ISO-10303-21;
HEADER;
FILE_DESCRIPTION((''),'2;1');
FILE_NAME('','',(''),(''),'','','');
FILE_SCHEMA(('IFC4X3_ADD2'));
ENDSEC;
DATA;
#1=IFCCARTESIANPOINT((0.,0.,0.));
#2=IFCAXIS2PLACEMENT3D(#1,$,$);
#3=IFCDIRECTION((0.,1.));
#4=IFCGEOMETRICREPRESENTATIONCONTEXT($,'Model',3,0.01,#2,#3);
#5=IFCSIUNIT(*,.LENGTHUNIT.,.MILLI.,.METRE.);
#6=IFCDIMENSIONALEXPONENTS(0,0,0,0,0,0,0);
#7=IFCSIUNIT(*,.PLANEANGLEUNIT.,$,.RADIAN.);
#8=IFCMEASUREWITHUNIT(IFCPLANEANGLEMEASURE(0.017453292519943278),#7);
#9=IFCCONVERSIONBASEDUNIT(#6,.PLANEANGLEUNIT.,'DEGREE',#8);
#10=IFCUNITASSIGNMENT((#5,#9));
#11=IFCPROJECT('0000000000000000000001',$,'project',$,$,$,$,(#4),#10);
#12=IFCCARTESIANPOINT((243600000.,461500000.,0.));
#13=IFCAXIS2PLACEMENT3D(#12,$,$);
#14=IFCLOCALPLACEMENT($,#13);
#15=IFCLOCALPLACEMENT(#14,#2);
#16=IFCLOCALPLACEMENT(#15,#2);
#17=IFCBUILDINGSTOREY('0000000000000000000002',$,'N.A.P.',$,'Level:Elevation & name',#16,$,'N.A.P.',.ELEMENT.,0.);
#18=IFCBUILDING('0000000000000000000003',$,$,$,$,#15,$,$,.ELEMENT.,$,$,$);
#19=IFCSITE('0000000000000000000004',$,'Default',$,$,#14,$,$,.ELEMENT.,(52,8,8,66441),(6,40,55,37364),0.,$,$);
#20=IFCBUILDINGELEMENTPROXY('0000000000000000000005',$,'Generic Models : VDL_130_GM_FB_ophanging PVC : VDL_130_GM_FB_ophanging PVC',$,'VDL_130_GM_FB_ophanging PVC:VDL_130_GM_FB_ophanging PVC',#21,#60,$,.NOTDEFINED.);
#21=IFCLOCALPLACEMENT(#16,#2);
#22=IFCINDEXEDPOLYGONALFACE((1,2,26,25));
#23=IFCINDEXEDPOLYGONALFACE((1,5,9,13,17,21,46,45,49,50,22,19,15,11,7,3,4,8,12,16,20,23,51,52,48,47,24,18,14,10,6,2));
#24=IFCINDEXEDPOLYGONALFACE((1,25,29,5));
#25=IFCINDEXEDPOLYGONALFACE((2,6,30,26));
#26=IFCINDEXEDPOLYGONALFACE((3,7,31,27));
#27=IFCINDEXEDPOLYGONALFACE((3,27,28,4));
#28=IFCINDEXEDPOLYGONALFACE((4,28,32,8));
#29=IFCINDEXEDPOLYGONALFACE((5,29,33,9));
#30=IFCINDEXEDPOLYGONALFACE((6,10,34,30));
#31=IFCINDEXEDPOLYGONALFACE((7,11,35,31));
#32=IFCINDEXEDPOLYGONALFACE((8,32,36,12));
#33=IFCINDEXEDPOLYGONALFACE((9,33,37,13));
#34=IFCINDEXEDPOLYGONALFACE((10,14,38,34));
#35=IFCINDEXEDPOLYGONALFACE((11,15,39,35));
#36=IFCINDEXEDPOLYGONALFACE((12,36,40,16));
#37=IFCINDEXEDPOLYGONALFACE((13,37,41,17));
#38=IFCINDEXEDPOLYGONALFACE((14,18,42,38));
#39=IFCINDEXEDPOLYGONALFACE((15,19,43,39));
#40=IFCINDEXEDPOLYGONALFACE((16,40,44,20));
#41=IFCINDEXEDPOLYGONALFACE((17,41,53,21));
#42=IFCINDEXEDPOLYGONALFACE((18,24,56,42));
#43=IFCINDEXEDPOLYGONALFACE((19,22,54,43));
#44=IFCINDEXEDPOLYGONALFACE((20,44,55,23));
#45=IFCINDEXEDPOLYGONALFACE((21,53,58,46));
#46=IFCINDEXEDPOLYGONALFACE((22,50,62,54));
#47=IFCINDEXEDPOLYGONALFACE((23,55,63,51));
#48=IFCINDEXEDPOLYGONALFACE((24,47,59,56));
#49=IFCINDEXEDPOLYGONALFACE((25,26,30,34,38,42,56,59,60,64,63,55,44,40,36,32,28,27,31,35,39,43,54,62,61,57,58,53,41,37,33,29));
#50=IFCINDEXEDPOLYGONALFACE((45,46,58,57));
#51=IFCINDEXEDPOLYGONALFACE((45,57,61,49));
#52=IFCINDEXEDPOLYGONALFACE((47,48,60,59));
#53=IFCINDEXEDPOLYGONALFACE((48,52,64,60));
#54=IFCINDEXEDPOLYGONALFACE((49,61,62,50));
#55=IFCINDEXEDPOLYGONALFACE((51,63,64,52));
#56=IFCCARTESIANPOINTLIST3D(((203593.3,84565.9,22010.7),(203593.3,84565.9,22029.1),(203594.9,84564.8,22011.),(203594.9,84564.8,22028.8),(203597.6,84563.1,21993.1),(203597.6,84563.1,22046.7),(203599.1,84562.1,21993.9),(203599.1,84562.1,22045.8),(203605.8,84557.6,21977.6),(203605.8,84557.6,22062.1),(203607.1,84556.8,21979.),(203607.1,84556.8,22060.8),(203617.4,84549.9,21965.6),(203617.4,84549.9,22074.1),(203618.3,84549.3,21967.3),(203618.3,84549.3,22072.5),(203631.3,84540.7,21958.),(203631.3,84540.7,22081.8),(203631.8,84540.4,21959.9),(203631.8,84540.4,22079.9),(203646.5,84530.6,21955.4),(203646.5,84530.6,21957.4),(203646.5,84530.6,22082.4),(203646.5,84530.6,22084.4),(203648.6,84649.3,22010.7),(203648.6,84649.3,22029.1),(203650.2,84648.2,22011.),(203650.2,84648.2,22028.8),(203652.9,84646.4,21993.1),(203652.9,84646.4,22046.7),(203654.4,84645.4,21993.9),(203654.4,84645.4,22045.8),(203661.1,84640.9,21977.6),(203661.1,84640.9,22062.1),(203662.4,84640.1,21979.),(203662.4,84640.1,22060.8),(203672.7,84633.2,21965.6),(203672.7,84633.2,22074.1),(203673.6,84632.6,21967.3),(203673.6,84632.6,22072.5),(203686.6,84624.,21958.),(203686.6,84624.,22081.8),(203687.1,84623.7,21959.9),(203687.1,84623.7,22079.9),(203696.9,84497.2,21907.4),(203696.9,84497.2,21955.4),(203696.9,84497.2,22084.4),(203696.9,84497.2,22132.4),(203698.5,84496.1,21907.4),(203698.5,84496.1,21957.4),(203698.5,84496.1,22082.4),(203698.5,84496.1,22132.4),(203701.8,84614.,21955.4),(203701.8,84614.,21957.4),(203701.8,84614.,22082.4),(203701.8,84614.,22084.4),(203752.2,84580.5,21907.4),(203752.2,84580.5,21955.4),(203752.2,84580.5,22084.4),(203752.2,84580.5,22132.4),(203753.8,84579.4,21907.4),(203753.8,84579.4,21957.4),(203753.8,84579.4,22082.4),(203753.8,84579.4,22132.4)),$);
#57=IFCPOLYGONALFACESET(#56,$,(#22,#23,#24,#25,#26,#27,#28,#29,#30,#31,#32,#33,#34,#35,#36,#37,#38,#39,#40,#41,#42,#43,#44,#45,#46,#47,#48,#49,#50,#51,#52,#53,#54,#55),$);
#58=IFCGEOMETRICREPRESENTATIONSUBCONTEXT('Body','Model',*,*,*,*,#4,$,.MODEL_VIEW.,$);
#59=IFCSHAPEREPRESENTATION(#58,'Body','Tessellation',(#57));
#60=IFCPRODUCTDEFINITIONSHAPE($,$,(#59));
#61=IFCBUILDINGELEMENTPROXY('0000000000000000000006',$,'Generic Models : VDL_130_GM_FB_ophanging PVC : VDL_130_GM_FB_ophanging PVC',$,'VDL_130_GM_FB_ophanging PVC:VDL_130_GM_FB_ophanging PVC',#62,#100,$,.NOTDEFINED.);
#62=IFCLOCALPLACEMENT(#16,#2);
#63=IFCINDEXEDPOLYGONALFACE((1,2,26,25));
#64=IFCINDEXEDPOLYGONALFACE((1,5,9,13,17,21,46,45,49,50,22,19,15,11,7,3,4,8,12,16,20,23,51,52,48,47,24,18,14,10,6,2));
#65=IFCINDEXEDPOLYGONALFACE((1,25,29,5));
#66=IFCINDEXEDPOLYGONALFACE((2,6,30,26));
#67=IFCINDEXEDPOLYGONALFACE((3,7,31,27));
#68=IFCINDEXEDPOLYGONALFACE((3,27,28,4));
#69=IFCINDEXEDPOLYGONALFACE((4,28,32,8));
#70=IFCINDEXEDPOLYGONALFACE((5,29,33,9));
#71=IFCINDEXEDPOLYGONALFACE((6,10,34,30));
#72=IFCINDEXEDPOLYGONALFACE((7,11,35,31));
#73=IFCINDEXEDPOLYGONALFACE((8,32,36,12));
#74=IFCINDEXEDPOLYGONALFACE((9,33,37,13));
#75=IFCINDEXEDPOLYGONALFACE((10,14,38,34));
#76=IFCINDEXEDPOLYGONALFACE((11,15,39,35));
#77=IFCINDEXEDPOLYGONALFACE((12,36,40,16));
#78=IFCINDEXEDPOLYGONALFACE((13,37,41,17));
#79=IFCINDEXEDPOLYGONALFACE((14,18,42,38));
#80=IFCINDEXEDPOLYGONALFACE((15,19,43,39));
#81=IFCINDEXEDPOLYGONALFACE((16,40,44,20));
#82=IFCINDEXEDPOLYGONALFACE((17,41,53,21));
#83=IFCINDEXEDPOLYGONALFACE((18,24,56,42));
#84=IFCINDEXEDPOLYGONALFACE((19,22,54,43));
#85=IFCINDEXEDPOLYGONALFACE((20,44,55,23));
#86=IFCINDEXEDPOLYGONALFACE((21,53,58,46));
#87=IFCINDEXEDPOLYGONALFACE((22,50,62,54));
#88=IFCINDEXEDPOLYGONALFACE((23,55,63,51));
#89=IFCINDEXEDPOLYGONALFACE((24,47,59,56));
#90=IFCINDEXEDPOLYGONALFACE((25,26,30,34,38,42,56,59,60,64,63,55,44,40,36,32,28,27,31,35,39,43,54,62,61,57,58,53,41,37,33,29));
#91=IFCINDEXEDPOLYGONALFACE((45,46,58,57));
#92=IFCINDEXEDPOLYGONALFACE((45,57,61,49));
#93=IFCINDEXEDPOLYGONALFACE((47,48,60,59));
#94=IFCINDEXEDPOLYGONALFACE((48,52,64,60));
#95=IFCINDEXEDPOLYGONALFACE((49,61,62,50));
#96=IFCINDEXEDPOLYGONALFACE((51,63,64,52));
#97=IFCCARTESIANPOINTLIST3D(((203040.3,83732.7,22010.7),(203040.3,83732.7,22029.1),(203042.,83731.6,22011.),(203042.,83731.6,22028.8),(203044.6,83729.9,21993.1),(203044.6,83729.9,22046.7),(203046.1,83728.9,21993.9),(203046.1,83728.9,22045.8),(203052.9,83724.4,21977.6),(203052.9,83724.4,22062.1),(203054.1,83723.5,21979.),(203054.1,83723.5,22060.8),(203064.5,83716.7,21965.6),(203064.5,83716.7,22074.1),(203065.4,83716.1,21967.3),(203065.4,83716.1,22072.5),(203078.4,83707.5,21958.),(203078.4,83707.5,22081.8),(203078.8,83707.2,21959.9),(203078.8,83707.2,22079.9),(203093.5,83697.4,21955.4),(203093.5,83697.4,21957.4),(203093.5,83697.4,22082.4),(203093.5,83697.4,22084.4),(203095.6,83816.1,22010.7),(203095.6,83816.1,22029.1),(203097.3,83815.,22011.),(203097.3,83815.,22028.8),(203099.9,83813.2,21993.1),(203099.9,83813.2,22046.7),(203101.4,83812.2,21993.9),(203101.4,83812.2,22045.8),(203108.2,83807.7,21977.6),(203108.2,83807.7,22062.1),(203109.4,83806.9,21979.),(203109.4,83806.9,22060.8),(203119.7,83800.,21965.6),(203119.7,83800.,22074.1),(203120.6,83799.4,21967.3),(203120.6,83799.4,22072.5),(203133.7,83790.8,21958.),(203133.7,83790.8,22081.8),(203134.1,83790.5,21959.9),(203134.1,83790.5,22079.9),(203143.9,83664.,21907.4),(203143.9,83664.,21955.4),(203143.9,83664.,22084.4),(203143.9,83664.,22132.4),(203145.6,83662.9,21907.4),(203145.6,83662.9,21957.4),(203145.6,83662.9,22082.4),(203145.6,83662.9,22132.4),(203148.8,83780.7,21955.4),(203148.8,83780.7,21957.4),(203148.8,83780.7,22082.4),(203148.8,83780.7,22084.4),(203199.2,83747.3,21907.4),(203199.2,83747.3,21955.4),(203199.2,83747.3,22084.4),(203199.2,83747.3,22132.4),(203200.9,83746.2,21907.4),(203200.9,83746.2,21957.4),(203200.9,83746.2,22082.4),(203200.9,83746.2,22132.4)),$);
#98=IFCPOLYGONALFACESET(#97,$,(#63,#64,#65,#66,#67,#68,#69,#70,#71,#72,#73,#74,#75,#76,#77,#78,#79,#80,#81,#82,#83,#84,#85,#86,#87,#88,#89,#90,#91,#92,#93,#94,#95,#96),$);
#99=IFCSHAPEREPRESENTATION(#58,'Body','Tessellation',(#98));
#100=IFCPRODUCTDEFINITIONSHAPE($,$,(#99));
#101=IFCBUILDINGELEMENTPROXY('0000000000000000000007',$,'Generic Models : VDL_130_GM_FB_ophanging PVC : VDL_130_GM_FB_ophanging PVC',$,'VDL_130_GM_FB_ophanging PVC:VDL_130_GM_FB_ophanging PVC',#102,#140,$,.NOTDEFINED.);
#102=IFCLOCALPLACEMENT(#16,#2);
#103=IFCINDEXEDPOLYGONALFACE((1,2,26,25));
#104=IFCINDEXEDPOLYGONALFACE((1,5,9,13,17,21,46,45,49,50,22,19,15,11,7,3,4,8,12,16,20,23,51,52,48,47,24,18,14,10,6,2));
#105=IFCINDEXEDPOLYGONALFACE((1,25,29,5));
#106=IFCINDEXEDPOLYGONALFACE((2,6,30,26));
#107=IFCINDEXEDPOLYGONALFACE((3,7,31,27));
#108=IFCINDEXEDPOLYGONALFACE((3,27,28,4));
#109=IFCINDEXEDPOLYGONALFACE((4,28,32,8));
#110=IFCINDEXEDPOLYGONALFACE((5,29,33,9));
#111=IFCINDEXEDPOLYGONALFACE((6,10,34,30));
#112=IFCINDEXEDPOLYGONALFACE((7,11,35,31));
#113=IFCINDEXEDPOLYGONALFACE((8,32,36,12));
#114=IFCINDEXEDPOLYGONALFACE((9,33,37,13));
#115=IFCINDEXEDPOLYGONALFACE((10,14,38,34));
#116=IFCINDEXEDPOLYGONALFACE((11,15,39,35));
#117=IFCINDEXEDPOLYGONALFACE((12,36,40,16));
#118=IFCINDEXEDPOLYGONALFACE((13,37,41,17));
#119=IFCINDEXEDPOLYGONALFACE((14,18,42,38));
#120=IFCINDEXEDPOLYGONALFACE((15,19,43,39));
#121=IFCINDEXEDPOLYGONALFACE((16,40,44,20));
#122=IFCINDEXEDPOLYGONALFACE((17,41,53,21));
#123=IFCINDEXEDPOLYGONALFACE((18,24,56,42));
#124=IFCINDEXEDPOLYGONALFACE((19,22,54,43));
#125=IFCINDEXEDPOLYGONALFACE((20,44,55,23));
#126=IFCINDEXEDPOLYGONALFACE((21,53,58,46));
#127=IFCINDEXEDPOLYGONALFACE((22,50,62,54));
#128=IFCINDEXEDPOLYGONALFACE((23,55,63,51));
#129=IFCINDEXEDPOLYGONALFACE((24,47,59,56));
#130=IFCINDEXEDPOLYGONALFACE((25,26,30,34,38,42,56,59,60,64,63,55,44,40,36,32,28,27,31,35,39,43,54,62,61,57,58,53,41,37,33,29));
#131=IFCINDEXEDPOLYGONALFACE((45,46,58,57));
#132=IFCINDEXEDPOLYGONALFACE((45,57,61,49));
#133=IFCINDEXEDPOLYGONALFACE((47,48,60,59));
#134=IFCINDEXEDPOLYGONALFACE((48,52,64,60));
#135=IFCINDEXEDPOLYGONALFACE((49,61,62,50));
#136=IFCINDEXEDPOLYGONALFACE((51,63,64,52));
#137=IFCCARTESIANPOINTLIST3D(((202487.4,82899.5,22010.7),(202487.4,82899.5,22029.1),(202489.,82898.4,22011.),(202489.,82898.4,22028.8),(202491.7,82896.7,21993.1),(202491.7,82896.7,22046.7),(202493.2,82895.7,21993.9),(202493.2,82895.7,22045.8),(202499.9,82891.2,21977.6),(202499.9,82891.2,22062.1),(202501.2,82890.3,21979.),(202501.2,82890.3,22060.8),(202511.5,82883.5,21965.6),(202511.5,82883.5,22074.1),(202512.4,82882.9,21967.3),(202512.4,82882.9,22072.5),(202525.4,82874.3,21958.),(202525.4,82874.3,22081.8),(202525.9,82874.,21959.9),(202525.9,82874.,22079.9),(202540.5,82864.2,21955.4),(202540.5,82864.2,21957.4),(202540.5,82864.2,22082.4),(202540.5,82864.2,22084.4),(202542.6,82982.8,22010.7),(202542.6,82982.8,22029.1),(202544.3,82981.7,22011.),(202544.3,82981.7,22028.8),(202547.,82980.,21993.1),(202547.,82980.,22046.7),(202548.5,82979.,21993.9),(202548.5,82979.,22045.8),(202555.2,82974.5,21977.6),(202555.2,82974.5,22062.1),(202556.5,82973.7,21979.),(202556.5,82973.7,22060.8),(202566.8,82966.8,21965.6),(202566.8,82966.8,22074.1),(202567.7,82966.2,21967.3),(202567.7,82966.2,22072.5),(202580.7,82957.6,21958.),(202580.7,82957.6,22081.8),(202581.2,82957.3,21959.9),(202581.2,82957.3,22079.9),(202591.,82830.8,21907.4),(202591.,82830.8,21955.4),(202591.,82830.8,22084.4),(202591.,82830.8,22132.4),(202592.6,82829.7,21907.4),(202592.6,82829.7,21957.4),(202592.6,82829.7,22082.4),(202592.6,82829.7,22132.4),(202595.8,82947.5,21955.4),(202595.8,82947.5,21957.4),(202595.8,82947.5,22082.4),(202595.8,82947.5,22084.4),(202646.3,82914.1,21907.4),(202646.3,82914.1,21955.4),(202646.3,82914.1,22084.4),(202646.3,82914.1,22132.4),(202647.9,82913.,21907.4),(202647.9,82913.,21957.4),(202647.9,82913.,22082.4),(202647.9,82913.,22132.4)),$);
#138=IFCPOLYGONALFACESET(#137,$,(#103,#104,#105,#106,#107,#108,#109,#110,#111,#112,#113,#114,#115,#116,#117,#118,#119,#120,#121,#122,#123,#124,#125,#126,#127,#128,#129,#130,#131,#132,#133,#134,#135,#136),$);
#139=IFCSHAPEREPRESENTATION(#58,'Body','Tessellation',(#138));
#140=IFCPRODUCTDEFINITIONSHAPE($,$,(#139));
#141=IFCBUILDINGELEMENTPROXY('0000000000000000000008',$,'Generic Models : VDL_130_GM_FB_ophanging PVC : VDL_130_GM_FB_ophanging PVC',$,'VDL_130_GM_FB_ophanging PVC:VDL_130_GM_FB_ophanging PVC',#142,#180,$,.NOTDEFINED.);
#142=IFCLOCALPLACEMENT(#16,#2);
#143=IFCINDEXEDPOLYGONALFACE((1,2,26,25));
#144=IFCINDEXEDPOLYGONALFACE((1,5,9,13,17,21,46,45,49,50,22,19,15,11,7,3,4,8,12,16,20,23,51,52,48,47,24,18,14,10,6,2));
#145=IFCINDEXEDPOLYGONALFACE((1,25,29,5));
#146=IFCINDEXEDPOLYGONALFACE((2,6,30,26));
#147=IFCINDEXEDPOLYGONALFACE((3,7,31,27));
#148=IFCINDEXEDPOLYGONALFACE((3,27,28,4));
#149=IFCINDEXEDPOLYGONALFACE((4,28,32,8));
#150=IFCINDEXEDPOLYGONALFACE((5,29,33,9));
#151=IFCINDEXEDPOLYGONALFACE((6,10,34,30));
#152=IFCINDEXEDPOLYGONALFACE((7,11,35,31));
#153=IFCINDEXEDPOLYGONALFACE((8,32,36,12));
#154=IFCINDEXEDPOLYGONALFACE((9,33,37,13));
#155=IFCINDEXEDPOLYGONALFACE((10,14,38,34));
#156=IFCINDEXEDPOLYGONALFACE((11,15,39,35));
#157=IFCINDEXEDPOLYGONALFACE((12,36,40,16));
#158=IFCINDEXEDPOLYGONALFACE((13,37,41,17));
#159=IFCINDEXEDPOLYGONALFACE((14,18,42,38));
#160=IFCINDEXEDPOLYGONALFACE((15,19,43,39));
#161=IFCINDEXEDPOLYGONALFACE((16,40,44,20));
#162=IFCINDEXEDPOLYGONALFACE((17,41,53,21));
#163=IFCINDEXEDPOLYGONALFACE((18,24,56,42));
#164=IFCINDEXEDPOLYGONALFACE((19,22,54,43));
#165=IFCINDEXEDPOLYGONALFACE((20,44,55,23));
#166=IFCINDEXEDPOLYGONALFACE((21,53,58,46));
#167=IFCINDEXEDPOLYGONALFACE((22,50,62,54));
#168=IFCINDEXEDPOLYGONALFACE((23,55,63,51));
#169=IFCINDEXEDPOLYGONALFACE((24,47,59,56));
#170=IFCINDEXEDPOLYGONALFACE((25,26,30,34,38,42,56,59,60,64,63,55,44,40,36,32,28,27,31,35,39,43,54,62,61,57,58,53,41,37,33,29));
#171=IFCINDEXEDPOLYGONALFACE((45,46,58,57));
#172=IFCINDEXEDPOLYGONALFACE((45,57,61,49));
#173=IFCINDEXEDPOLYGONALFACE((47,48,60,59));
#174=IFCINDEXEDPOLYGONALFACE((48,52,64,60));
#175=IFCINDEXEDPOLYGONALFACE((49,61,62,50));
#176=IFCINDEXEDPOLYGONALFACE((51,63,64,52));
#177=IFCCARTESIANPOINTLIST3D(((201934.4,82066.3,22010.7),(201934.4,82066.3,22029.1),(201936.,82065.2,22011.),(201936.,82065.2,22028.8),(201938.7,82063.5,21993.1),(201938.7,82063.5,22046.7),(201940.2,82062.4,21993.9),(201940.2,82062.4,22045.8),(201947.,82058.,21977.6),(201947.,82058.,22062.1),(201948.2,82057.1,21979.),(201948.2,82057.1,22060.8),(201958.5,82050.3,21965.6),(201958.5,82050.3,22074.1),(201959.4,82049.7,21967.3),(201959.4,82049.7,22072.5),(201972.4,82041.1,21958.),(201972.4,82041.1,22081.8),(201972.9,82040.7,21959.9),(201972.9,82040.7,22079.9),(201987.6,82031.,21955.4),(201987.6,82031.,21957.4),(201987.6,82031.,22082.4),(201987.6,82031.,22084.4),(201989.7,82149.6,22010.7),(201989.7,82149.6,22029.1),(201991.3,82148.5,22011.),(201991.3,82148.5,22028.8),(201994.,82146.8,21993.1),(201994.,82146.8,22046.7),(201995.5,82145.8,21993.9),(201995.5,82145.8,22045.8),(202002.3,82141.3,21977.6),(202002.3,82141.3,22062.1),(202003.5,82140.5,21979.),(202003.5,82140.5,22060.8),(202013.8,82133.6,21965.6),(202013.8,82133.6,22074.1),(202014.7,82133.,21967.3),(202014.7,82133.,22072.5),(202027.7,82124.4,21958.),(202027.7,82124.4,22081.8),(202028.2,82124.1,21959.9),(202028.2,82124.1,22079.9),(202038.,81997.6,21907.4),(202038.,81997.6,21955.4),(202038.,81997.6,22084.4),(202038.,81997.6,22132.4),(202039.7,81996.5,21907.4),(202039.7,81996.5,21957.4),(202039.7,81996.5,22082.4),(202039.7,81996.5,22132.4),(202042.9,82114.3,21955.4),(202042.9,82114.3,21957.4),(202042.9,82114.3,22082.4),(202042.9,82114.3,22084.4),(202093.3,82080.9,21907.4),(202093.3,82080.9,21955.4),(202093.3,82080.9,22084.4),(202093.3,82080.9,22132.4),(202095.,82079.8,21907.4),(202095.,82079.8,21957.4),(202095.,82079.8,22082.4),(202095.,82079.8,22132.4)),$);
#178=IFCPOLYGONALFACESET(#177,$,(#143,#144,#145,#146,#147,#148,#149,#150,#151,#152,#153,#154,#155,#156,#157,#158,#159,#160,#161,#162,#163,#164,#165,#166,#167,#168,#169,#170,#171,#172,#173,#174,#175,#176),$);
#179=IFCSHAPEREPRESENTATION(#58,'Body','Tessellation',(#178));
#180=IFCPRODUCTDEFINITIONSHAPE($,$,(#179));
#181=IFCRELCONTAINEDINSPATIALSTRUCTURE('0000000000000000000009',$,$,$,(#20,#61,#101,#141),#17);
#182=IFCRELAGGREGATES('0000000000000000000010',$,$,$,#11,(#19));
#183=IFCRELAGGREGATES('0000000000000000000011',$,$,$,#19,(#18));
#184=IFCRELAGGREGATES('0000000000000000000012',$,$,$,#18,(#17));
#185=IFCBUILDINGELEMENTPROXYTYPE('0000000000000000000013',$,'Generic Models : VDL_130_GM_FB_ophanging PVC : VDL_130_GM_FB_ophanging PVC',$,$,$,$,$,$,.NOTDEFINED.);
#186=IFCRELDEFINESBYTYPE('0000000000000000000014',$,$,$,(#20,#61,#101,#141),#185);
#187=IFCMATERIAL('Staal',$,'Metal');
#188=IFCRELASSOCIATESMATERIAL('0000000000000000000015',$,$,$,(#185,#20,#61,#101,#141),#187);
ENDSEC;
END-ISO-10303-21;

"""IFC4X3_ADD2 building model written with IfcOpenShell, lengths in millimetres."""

from ifc_helpers import new_model, entity, si_unit, converted_unit, direction, frame, frame_2d, origin, place, context, subcontext, project, spatial, polyline, circle_curve, parameter, trimmed, segment, composite_curve, outline, extrude, source, transform, mapped, material, type_object, type_shapes, element, save


model = new_model("IFC4X3_ADD2")

# Units and contexts
model_context = context("Model", 3, precision=0.01, world=origin(), true_north=direction((0.0, 1.0)))
body_context = subcontext(model_context, "Body", "Model", "MODEL_VIEW")
ifc_project = project(units=[si_unit("LENGTHUNIT", "METRE", prefix="MILLI"), converted_unit("PLANEANGLEUNIT", "DEGREE", entity("IfcPlaneAngleMeasure", 0.017453292519943278), si_unit("PLANEANGLEUNIT", "RADIAN"), dimensions=[0, 0, 0, 0, 0, 0, 0])], contexts=[model_context])

# Site, building, storey
site_placement = place(None, frame((243600000.0, 461500000.0, 0.0)))
site = spatial("IfcSite", under=ifc_project, at=site_placement, Name="Default", CompositionType="ELEMENT", RefLatitude=(52, 8, 8, 66441), RefLongitude=(6, 40, 55, 37364), RefElevation=0.0)
building_placement = place(site_placement, origin())
building = spatial("IfcBuilding", under=site, at=building_placement, CompositionType="ELEMENT")
storey_placement = place(building_placement, origin())
storey = spatial("IfcBuildingStorey", under=building, at=storey_placement, Name="N.A.P.", ObjectType="Level:Elevation & name", LongName="N.A.P.", CompositionType="ELEMENT", Elevation=0.0)

# Building element proxies
ifc_material_1 = material(Name="Staal", Category="Metal")
building_element_proxy_type_1 = type_object("IfcBuildingElementProxyType", Name="Generic Models : VDL_130_GM_FB_ophanging PVC : VDL_130_GM_FB_ophanging PVC", PredefinedType="NOTDEFINED", material=ifc_material_1)
shared_shape_1 = source(origin(), body_context, "Body", "SweptSolid", [
    extrude(outline(composite_curve([segment(polyline([(-41.0, 62.5), (21.5, 62.5)]), True, "CONTINUOUS"), segment(polyline([(21.5, 62.5), (21.5, 112.5)]), True, "CONTINUOUS"), segment(polyline([(21.5, 112.5), (19.5, 112.5)]), True, "CONTINUOUS"), segment(polyline([(19.5, 112.5), (19.5, 64.5)]), True, "CONTINUOUS"), segment(polyline([(19.5, 64.5), (-41.0, 64.5)]), True, "CONTINUOUS"), segment(trimmed(circle_curve(frame_2d((-41.0, 0.0), x_axis=(0.0, 1.0)), 64.5), [parameter(0.0)], [parameter(180.0)], True, "PARAMETER"), True, "CONTINUOUS"), segment(polyline([(-41.0, -64.5), (19.5, -64.5)]), True, "CONTINUOUS"), segment(polyline([(19.5, -64.5), (19.5, -112.5)]), True, "CONTINUOUS"), segment(polyline([(19.5, -112.5), (21.5, -112.5)]), True, "CONTINUOUS"), segment(polyline([(21.5, -112.5), (21.5, -62.5)]), True, "CONTINUOUS"), segment(polyline([(21.5, -62.5), (-41.0, -62.5)]), True, "CONTINUOUS"), segment(trimmed(circle_curve(frame_2d((-41.0, 0.0), x_axis=(0.0, 1.0)), 62.5), [parameter(0.0)], [parameter(180.0)], True, "PARAMETER"), False, "CONTINUOUS")], self_intersect=False)), frame((0.0, -50.0, 21.5), z_axis=(0.0, 1.0, 0.0), x_axis=(0.0, 0.0, -1.0)), (0.0, 0.0, 1.0), 100.0),
])
type_shapes(building_element_proxy_type_1, [shared_shape_1])
for number, where, z_axis, x_axis, name in (
    (1, (203726.2, 84537.7, 22019.9), (-0.833209, 0.552959, 0.0), (0.0, 0.0, 1.0), "Generic Models : VDL_130_GM_FB_ophanging PVC : VDL_130_GM_FB_ophanging PVC"),
    (2, (203173.2, 83704.5, 22019.9), (-0.833209, 0.552959, 0.0), (0.0, 0.0, 1.0), "Generic Models : VDL_130_GM_FB_ophanging PVC : VDL_130_GM_FB_ophanging PVC"),
    (3, (202620.3, 82871.3, 22019.9), (-0.833209, 0.552959, 0.0), (0.0, 0.0, 1.0), "Generic Models : VDL_130_GM_FB_ophanging PVC : VDL_130_GM_FB_ophanging PVC"),
    (4, (202067.3, 82038.1, 22019.9), (-0.833209, 0.552959, 0.0), (0.0, 0.0, 1.0), "Generic Models : VDL_130_GM_FB_ophanging PVC : VDL_130_GM_FB_ophanging PVC"),
):
    element("IfcBuildingElementProxy", number, at=place(storey_placement, frame(where, z_axis=z_axis, x_axis=x_axis)), inside=storey, type_object=building_element_proxy_type_1, material=ifc_material_1, Name=name, ObjectType="VDL_130_GM_FB_ophanging PVC:VDL_130_GM_FB_ophanging PVC", PredefinedType="NOTDEFINED", context=body_context, shape_type="MappedRepresentation", body=[
        mapped(shared_shape_1, transform((0.0, 0.0, 0.0), scale=1.0)),
    ])

save(model, "model.ifc")
